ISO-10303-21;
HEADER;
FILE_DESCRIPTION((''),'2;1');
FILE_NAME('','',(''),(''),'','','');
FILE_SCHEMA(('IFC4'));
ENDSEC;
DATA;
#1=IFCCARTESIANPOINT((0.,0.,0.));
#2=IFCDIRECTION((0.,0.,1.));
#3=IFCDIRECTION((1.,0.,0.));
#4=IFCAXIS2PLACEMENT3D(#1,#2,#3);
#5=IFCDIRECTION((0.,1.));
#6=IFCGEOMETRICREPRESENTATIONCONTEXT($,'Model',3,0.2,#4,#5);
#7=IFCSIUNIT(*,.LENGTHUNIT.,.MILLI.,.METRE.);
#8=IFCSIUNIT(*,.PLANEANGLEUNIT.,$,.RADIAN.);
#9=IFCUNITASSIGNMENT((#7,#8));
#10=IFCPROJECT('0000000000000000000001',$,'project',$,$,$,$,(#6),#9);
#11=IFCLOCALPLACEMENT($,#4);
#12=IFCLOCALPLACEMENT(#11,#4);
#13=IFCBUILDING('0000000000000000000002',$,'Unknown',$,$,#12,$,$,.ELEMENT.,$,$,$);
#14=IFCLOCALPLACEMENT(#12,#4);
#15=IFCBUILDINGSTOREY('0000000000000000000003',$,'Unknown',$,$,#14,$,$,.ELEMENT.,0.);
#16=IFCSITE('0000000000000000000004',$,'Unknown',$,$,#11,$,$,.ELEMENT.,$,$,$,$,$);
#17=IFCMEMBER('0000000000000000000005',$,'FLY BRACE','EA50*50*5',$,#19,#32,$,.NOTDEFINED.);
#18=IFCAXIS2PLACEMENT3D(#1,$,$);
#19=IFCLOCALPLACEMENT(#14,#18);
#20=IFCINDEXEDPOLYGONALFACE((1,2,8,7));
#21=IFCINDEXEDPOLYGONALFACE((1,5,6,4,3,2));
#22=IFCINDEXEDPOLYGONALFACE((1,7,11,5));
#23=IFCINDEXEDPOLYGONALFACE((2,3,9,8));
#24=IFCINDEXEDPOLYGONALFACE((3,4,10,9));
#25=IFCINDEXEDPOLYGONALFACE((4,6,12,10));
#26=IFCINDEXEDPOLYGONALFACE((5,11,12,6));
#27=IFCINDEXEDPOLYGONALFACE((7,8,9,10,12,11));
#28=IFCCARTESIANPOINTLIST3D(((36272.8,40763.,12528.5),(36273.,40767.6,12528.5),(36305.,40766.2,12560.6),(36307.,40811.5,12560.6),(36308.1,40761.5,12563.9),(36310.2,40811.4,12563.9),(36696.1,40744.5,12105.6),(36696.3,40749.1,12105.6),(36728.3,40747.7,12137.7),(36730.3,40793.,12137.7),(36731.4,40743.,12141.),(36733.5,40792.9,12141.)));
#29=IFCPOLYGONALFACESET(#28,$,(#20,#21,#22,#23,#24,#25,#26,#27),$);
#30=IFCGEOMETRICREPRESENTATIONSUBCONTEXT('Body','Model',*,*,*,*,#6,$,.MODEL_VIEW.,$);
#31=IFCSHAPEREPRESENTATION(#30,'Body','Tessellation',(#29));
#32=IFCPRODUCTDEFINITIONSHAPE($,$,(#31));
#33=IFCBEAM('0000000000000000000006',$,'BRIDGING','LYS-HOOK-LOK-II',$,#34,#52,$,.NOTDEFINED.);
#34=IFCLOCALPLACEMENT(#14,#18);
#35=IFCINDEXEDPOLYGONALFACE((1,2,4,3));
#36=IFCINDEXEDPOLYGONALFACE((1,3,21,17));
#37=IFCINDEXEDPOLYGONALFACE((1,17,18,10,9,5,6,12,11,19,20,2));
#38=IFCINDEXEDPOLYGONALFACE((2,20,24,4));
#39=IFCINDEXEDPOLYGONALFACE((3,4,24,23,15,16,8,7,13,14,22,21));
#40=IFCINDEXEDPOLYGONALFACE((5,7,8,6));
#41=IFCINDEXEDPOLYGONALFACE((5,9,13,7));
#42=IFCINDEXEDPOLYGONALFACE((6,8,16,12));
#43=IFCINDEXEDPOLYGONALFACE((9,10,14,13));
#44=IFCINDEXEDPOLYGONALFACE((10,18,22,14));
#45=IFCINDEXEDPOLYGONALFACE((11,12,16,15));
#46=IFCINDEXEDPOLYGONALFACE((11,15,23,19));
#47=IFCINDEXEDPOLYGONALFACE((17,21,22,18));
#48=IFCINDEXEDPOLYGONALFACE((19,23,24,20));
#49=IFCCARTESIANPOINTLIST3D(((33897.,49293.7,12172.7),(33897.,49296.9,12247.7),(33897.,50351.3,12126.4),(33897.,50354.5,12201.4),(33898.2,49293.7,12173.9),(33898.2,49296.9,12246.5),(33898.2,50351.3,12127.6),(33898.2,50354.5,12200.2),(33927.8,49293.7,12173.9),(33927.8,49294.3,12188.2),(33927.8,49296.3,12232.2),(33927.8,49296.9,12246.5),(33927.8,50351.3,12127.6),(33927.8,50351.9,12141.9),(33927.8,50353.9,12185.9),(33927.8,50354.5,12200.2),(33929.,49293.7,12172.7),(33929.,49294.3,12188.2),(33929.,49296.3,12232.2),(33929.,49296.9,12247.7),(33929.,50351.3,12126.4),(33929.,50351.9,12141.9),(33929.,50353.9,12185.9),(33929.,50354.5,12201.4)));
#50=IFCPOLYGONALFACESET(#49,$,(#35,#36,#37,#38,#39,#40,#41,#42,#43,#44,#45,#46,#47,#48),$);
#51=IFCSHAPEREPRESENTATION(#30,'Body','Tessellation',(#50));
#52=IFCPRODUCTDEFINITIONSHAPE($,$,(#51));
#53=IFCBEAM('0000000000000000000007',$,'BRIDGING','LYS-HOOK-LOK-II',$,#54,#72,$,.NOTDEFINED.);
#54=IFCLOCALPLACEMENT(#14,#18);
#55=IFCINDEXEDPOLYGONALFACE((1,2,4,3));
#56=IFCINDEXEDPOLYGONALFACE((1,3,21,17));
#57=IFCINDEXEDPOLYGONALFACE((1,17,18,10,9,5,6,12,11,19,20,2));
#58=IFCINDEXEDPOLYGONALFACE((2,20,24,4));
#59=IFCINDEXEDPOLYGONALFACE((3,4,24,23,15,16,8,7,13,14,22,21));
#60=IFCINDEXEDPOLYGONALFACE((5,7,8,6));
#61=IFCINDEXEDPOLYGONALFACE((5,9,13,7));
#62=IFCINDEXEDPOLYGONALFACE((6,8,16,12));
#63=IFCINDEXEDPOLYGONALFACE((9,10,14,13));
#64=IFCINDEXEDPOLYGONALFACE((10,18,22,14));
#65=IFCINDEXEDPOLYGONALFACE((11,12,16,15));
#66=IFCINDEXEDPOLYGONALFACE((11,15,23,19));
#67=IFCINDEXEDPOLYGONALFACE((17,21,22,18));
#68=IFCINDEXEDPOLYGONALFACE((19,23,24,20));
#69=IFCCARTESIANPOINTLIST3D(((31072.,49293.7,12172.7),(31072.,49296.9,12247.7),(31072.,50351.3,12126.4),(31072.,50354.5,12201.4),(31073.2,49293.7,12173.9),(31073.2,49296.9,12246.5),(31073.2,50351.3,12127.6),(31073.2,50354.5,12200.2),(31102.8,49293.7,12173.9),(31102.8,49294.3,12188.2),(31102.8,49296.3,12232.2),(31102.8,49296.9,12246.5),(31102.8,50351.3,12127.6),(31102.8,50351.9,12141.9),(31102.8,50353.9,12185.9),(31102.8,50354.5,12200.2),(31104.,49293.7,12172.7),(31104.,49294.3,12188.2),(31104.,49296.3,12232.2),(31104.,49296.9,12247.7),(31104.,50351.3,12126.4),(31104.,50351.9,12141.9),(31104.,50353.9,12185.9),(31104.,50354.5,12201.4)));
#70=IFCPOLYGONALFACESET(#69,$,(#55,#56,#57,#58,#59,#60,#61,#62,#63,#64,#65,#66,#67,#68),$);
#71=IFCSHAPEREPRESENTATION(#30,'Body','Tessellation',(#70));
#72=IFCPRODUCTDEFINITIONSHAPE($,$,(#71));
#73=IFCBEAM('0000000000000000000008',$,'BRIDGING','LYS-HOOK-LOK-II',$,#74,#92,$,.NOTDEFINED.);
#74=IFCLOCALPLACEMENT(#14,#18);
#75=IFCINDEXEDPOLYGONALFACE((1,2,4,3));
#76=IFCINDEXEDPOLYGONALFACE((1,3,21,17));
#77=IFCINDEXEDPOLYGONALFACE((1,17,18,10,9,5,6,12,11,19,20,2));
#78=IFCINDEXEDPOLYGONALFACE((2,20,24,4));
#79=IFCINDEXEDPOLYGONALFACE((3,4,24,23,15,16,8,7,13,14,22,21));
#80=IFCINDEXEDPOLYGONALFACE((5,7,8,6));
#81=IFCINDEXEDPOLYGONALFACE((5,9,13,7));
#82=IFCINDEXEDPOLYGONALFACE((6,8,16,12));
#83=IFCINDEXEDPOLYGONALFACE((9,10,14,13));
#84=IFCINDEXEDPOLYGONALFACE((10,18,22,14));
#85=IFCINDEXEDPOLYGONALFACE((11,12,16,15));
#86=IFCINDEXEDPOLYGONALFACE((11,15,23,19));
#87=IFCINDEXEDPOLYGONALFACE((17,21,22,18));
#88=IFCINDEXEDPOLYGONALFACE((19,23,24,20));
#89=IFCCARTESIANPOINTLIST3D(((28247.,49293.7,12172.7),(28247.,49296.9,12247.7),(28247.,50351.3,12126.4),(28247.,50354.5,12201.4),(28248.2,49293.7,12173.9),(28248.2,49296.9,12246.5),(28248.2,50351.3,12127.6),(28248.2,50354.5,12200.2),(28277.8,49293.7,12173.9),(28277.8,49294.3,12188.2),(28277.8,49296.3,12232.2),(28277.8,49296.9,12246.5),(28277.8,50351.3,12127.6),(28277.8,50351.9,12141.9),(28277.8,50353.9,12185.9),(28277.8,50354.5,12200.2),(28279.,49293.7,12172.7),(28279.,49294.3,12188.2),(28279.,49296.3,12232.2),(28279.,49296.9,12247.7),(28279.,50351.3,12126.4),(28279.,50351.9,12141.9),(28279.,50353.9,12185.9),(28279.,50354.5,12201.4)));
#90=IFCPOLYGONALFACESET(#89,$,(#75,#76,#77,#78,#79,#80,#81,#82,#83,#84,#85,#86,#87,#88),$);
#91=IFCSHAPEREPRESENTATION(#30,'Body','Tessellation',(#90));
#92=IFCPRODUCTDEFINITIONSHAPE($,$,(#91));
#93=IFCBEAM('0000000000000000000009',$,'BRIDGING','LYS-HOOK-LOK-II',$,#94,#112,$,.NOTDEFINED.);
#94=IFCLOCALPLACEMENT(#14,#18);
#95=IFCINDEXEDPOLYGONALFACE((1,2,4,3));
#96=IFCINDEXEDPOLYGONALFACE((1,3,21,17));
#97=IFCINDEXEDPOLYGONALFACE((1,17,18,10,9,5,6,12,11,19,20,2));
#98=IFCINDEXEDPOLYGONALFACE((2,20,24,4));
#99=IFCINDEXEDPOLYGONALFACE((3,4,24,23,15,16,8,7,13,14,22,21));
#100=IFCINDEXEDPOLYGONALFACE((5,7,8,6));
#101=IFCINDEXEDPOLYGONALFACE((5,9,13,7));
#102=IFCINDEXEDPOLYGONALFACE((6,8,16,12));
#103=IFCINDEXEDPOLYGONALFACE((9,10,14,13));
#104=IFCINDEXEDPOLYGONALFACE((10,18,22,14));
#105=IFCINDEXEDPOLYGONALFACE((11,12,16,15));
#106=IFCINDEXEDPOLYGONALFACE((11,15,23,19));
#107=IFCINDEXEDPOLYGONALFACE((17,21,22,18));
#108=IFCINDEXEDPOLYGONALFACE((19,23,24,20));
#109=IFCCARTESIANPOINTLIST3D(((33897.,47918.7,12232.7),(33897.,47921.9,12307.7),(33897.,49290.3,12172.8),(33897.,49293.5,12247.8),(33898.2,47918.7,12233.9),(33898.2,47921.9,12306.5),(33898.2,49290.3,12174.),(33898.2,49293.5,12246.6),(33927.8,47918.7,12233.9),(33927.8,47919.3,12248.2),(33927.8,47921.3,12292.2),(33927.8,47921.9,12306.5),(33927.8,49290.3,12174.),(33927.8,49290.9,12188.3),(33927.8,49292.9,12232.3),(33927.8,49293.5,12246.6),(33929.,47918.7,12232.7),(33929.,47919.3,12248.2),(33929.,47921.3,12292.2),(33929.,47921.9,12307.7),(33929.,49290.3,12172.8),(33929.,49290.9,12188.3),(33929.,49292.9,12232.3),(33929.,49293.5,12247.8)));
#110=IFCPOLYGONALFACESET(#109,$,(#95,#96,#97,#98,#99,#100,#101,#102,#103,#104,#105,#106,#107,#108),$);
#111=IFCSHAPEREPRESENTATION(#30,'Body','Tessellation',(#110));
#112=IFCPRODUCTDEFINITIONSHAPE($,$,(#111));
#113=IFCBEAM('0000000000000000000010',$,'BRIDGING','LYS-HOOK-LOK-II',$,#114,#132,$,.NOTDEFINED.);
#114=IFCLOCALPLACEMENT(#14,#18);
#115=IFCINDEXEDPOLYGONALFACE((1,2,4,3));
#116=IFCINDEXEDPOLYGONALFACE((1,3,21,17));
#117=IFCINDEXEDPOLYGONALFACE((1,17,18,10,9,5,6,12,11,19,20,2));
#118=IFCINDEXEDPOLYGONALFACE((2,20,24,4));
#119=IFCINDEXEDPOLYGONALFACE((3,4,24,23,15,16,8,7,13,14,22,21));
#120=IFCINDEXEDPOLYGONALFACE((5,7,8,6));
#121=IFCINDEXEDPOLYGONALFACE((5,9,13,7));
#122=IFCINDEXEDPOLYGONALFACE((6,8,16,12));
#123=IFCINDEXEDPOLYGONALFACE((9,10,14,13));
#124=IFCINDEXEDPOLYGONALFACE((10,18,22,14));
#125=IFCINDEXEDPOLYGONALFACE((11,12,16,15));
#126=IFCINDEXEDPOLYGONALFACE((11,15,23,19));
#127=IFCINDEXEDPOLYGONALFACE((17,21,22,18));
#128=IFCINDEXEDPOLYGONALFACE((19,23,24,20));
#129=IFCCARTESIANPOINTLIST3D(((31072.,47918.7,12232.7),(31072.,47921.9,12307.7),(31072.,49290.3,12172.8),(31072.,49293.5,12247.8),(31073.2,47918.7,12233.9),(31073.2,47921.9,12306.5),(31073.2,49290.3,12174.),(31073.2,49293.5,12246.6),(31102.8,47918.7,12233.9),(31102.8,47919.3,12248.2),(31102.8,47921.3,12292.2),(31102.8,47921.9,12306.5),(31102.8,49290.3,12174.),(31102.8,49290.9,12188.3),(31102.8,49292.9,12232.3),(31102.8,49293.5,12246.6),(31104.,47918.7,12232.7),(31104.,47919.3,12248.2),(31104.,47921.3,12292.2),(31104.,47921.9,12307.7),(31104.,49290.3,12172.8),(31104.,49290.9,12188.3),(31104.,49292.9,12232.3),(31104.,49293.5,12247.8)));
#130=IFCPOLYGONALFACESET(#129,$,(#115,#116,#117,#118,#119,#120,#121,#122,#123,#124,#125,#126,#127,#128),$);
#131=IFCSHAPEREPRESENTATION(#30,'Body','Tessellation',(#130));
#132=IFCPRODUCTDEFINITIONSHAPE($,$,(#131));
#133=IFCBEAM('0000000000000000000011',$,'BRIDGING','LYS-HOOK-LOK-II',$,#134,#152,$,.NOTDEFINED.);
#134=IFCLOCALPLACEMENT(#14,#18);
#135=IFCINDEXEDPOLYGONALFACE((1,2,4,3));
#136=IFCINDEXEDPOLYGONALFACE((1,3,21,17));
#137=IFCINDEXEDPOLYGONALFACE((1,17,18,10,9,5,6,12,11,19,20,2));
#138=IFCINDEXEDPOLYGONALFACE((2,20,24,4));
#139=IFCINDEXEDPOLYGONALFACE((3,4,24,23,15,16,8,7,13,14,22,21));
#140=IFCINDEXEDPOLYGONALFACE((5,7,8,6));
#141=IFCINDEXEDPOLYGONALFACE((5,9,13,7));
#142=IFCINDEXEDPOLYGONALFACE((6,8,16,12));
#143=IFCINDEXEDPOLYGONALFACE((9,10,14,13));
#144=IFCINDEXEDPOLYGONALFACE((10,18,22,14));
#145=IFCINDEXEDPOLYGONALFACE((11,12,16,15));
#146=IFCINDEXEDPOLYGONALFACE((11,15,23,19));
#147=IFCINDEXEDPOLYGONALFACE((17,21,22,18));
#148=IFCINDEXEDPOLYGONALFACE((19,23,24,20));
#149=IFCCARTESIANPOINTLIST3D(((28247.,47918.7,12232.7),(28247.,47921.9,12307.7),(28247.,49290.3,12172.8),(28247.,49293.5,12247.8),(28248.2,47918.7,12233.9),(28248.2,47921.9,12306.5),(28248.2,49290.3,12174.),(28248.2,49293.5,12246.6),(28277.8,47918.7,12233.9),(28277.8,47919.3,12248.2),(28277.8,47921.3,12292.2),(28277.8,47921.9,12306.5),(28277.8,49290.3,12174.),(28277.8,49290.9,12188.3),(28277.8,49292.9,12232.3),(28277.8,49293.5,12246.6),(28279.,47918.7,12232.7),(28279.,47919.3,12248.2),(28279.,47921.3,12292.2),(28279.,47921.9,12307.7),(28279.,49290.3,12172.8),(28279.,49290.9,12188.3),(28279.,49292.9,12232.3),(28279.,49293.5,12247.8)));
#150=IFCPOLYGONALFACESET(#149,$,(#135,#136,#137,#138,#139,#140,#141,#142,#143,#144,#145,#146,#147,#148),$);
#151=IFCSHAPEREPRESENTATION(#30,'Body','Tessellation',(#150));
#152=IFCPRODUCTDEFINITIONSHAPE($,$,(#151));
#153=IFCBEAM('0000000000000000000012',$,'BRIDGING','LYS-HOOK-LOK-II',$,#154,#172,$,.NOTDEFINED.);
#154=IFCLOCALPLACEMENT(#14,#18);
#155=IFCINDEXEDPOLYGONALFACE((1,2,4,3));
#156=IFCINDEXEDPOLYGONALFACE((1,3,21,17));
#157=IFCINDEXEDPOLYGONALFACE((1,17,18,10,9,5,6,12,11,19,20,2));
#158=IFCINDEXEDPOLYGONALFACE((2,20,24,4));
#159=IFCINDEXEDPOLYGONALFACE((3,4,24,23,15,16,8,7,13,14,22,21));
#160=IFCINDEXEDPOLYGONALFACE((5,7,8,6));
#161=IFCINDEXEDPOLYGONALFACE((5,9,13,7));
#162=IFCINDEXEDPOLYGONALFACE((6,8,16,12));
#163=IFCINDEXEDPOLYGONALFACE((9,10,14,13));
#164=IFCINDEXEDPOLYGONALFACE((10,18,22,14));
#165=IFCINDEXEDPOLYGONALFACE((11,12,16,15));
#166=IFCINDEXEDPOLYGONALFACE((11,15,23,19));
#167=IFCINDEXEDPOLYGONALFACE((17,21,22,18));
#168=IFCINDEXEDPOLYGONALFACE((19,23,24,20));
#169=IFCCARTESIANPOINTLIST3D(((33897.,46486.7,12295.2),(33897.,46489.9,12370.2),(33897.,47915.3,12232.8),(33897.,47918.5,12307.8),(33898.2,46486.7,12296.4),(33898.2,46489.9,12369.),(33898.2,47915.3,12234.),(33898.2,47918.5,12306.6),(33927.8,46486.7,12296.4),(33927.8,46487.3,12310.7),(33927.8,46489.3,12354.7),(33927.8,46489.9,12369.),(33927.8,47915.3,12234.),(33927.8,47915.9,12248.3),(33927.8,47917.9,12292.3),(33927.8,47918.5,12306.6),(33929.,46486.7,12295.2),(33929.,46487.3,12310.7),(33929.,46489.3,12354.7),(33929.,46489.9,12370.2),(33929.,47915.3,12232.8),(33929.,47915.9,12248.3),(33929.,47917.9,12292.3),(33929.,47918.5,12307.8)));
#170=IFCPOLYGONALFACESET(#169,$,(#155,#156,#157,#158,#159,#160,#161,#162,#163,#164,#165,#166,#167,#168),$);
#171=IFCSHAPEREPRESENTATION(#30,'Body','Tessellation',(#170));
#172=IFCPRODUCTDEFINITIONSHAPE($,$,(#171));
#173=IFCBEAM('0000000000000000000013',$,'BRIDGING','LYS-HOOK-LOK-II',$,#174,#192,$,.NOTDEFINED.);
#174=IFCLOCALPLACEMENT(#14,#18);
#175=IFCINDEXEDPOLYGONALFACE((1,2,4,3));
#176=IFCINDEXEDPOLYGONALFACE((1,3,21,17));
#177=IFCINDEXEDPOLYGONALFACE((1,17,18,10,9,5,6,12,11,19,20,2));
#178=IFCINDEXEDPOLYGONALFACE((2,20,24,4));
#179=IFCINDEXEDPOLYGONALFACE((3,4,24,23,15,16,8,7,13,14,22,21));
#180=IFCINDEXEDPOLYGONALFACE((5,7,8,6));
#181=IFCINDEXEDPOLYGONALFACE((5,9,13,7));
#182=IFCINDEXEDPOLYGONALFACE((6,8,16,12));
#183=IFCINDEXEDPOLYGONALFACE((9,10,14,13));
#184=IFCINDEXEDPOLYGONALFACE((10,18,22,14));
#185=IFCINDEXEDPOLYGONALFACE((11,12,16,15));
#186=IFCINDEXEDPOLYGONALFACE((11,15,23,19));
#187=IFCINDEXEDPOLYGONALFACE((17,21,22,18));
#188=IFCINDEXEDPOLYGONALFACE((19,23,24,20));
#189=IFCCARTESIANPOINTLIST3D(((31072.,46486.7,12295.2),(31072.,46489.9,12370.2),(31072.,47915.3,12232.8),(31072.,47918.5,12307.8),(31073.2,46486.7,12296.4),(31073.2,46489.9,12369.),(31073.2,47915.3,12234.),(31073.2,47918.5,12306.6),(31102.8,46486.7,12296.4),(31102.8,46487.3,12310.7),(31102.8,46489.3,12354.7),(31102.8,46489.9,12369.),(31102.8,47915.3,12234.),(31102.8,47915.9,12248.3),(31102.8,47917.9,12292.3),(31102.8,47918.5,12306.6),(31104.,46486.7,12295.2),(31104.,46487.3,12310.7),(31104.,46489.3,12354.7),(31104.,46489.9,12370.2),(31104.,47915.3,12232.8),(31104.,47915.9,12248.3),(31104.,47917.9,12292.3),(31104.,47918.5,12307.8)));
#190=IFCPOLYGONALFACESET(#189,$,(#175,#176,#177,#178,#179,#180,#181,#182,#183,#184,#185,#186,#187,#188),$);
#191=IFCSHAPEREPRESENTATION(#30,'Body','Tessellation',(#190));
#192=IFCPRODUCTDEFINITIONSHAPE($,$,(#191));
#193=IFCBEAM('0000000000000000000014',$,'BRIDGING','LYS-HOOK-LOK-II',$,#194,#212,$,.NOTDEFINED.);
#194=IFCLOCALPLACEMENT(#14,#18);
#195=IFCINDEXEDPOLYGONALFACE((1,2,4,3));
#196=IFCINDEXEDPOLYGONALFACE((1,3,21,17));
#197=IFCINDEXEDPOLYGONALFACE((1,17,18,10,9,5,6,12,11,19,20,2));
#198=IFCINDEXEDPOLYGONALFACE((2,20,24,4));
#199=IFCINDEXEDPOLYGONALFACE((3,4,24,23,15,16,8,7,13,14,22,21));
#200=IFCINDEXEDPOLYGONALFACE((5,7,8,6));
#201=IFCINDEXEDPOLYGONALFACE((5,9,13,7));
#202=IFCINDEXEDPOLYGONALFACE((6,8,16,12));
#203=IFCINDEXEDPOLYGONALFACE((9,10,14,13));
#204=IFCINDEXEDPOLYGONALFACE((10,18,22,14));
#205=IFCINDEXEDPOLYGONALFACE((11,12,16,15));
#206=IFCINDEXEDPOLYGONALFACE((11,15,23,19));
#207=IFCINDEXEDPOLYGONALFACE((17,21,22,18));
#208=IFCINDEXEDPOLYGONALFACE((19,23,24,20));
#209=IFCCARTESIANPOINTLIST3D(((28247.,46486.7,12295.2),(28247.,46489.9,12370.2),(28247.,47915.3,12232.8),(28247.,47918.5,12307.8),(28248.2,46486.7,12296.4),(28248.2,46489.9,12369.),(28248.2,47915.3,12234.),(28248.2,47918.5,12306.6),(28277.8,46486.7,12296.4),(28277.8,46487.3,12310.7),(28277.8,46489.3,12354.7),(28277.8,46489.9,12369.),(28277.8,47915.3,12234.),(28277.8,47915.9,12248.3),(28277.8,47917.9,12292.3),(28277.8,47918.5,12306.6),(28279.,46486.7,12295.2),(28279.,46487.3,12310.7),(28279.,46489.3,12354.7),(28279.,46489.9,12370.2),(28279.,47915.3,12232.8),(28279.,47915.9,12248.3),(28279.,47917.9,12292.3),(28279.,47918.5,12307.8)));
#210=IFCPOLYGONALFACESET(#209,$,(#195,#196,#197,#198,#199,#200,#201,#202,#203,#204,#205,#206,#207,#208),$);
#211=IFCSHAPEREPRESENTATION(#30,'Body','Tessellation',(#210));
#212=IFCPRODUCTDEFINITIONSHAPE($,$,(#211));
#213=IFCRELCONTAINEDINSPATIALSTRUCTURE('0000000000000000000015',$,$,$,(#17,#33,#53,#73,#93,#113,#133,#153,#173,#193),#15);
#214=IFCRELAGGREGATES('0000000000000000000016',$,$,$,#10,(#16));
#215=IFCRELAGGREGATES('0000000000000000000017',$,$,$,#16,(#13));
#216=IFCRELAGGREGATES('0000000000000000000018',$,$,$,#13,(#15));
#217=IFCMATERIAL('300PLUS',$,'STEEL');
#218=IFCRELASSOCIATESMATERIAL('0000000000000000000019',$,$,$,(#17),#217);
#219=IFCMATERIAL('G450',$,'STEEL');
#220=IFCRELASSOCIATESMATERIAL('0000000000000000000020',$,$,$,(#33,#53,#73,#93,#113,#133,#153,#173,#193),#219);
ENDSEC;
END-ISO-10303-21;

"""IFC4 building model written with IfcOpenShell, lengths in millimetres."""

from ifc_helpers import new_model, si_unit, direction, frame, origin_with_axes, place, context, subcontext, project, spatial, line, indexed_curve, outline, extrude, material, element, save


model = new_model("IFC4")

# Units and contexts
model_context = context("Model", 3, precision=0.2, world=origin_with_axes(), true_north=direction((0.0, 1.0)))
body_context = subcontext(model_context, "Body", "Model", "MODEL_VIEW")
ifc_project = project(units=[si_unit("LENGTHUNIT", "METRE", prefix="MILLI"), si_unit("PLANEANGLEUNIT", "RADIAN")], contexts=[model_context])

# Site, building, storey
site_placement = place(None, origin_with_axes())
site = spatial("IfcSite", under=ifc_project, at=site_placement, Name="Unknown", CompositionType="ELEMENT")
building_placement = place(site_placement, origin_with_axes())
building = spatial("IfcBuilding", under=site, at=building_placement, Name="Unknown", CompositionType="ELEMENT")
storey_placement = place(building_placement, origin_with_axes())
storey = spatial("IfcBuildingStorey", under=building, at=storey_placement, Name="Unknown", CompositionType="ELEMENT", Elevation=0.0)

# Member
ifc_material_1 = material(Name="300PLUS", Category="STEEL")
member_placement = place(storey_placement, frame((36714.8, 40768.7, 12123.3), z_axis=(-0.705761, 0.030845, -0.707778), x_axis=(-0.707103, 0.030903, 0.706435)))
element("IfcMember", 1, at=member_placement, inside=storey, material=ifc_material_1, Name="FLY BRACE", Description="EA50*50*5", PredefinedType="NOTDEFINED", context=body_context, shape_type="SolidModel", body=[
    extrude(outline(indexed_curve([(-25.0, -25.0), (25.0, -25.0), (25.0, -20.4), (-20.4, -20.4), (-20.4, 25.0), (-25.0, 25.0)], segments=[line(1, 2, 3, 4, 5, 6, 1)])), frame((0.0, 0.0, 0.0), z_axis=(-1.0, 0.0, 0.0), x_axis=(0.0, 0.0, 1.0)), (0.0, 0.0, -1.0), 598.6),
])

# Beams
ifc_material_2 = material(Name="G450", Category="STEEL")
for number, where, z_axis, x_axis, name in (
    (2, (33913.0, 49295.3, 12210.2), (1.0, 0.0, 0.0), (0.0, 0.999043, -0.043736), "BRIDGING"),
    (3, (31088.0, 49295.3, 12210.2), (1.0, 0.0, 0.0), (0.0, 0.999043, -0.043736), "BRIDGING"),
    (4, (28263.0, 49295.3, 12210.2), (1.0, 0.0, 0.0), (0.0, 0.999043, -0.043736), "BRIDGING"),
):
    element("IfcBeam", number, at=place(storey_placement, frame(where, z_axis=z_axis, x_axis=x_axis)), inside=storey, material=ifc_material_2, Name=name, Description="LYS-HOOK-LOK-II", PredefinedType="NOTDEFINED", context=body_context, shape_type="SolidModel", body=[
        extrude(outline(indexed_curve([(16.0, -37.5), (16.0, -22.0), (14.8, -22.0), (14.8, -36.3), (-14.8, -36.3), (-14.8, 36.3), (14.8, 36.3), (14.8, 22.0), (16.0, 22.0), (16.0, 37.5), (-16.0, 37.5), (-16.0, -37.5)], segments=[line(1, 2, 3, 4, 5, 6, 7, 8, 9, 10, 11, 12, 1)])), frame((0.0, 0.0, 0.0), z_axis=(-1.0, 0.0, 0.0), x_axis=(0.0, 0.0, 1.0)), (0.0, 0.0, -1.0), 1058.6),
    ])
for number, where, z_axis, x_axis, name in (
    (5, (33913.0, 47920.3, 12270.2), (1.0, 0.0, 0.0), (0.0, 0.999048, -0.04363), "BRIDGING"),
    (6, (31088.0, 47920.3, 12270.2), (1.0, 0.0, 0.0), (0.0, 0.999048, -0.04363), "BRIDGING"),
    (7, (28263.0, 47920.3, 12270.2), (1.0, 0.0, 0.0), (0.0, 0.999048, -0.04363), "BRIDGING"),
):
    element("IfcBeam", number, at=place(storey_placement, frame(where, z_axis=z_axis, x_axis=x_axis)), inside=storey, material=ifc_material_2, Name=name, Description="LYS-HOOK-LOK-II", PredefinedType="NOTDEFINED", context=body_context, shape_type="SolidModel", body=[
        extrude(outline(indexed_curve([(16.0, -37.5), (16.0, -22.0), (14.8, -22.0), (14.8, -36.3), (-14.8, -36.3), (-14.8, 36.3), (14.8, 36.3), (14.8, 22.0), (16.0, 22.0), (16.0, 37.5), (-16.0, 37.5), (-16.0, -37.5)], segments=[line(1, 2, 3, 4, 5, 6, 7, 8, 9, 10, 11, 12, 1)])), frame((0.0, 0.0, 0.0), z_axis=(-1.0, 0.0, 0.0), x_axis=(0.0, 0.0, 1.0)), (0.0, 0.0, -1.0), 1372.9),
    ])
for number, where, z_axis, x_axis, name in (
    (8, (33913.0, 46488.3, 12332.7), (1.0, 0.0, 0.0), (0.0, 0.999047, -0.043638), "BRIDGING"),
    (9, (31088.0, 46488.3, 12332.7), (1.0, 0.0, 0.0), (0.0, 0.999047, -0.043638), "BRIDGING"),
    (10, (28263.0, 46488.3, 12332.7), (1.0, 0.0, 0.0), (0.0, 0.999047, -0.043638), "BRIDGING"),
):
    element("IfcBeam", number, at=place(storey_placement, frame(where, z_axis=z_axis, x_axis=x_axis)), inside=storey, material=ifc_material_2, Name=name, Description="LYS-HOOK-LOK-II", PredefinedType="NOTDEFINED", context=body_context, shape_type="SolidModel", body=[
        extrude(outline(indexed_curve([(16.0, -37.5), (16.0, -22.0), (14.8, -22.0), (14.8, -36.3), (-14.8, -36.3), (-14.8, 36.3), (14.8, 36.3), (14.8, 22.0), (16.0, 22.0), (16.0, 37.5), (-16.0, 37.5), (-16.0, -37.5)], segments=[line(1, 2, 3, 4, 5, 6, 7, 8, 9, 10, 11, 12, 1)])), frame((0.0, 0.0, 0.0), z_axis=(-1.0, 0.0, 0.0), x_axis=(0.0, 0.0, 1.0)), (0.0, 0.0, -1.0), 1430.0),
    ])

save(model, "model.ifc")
